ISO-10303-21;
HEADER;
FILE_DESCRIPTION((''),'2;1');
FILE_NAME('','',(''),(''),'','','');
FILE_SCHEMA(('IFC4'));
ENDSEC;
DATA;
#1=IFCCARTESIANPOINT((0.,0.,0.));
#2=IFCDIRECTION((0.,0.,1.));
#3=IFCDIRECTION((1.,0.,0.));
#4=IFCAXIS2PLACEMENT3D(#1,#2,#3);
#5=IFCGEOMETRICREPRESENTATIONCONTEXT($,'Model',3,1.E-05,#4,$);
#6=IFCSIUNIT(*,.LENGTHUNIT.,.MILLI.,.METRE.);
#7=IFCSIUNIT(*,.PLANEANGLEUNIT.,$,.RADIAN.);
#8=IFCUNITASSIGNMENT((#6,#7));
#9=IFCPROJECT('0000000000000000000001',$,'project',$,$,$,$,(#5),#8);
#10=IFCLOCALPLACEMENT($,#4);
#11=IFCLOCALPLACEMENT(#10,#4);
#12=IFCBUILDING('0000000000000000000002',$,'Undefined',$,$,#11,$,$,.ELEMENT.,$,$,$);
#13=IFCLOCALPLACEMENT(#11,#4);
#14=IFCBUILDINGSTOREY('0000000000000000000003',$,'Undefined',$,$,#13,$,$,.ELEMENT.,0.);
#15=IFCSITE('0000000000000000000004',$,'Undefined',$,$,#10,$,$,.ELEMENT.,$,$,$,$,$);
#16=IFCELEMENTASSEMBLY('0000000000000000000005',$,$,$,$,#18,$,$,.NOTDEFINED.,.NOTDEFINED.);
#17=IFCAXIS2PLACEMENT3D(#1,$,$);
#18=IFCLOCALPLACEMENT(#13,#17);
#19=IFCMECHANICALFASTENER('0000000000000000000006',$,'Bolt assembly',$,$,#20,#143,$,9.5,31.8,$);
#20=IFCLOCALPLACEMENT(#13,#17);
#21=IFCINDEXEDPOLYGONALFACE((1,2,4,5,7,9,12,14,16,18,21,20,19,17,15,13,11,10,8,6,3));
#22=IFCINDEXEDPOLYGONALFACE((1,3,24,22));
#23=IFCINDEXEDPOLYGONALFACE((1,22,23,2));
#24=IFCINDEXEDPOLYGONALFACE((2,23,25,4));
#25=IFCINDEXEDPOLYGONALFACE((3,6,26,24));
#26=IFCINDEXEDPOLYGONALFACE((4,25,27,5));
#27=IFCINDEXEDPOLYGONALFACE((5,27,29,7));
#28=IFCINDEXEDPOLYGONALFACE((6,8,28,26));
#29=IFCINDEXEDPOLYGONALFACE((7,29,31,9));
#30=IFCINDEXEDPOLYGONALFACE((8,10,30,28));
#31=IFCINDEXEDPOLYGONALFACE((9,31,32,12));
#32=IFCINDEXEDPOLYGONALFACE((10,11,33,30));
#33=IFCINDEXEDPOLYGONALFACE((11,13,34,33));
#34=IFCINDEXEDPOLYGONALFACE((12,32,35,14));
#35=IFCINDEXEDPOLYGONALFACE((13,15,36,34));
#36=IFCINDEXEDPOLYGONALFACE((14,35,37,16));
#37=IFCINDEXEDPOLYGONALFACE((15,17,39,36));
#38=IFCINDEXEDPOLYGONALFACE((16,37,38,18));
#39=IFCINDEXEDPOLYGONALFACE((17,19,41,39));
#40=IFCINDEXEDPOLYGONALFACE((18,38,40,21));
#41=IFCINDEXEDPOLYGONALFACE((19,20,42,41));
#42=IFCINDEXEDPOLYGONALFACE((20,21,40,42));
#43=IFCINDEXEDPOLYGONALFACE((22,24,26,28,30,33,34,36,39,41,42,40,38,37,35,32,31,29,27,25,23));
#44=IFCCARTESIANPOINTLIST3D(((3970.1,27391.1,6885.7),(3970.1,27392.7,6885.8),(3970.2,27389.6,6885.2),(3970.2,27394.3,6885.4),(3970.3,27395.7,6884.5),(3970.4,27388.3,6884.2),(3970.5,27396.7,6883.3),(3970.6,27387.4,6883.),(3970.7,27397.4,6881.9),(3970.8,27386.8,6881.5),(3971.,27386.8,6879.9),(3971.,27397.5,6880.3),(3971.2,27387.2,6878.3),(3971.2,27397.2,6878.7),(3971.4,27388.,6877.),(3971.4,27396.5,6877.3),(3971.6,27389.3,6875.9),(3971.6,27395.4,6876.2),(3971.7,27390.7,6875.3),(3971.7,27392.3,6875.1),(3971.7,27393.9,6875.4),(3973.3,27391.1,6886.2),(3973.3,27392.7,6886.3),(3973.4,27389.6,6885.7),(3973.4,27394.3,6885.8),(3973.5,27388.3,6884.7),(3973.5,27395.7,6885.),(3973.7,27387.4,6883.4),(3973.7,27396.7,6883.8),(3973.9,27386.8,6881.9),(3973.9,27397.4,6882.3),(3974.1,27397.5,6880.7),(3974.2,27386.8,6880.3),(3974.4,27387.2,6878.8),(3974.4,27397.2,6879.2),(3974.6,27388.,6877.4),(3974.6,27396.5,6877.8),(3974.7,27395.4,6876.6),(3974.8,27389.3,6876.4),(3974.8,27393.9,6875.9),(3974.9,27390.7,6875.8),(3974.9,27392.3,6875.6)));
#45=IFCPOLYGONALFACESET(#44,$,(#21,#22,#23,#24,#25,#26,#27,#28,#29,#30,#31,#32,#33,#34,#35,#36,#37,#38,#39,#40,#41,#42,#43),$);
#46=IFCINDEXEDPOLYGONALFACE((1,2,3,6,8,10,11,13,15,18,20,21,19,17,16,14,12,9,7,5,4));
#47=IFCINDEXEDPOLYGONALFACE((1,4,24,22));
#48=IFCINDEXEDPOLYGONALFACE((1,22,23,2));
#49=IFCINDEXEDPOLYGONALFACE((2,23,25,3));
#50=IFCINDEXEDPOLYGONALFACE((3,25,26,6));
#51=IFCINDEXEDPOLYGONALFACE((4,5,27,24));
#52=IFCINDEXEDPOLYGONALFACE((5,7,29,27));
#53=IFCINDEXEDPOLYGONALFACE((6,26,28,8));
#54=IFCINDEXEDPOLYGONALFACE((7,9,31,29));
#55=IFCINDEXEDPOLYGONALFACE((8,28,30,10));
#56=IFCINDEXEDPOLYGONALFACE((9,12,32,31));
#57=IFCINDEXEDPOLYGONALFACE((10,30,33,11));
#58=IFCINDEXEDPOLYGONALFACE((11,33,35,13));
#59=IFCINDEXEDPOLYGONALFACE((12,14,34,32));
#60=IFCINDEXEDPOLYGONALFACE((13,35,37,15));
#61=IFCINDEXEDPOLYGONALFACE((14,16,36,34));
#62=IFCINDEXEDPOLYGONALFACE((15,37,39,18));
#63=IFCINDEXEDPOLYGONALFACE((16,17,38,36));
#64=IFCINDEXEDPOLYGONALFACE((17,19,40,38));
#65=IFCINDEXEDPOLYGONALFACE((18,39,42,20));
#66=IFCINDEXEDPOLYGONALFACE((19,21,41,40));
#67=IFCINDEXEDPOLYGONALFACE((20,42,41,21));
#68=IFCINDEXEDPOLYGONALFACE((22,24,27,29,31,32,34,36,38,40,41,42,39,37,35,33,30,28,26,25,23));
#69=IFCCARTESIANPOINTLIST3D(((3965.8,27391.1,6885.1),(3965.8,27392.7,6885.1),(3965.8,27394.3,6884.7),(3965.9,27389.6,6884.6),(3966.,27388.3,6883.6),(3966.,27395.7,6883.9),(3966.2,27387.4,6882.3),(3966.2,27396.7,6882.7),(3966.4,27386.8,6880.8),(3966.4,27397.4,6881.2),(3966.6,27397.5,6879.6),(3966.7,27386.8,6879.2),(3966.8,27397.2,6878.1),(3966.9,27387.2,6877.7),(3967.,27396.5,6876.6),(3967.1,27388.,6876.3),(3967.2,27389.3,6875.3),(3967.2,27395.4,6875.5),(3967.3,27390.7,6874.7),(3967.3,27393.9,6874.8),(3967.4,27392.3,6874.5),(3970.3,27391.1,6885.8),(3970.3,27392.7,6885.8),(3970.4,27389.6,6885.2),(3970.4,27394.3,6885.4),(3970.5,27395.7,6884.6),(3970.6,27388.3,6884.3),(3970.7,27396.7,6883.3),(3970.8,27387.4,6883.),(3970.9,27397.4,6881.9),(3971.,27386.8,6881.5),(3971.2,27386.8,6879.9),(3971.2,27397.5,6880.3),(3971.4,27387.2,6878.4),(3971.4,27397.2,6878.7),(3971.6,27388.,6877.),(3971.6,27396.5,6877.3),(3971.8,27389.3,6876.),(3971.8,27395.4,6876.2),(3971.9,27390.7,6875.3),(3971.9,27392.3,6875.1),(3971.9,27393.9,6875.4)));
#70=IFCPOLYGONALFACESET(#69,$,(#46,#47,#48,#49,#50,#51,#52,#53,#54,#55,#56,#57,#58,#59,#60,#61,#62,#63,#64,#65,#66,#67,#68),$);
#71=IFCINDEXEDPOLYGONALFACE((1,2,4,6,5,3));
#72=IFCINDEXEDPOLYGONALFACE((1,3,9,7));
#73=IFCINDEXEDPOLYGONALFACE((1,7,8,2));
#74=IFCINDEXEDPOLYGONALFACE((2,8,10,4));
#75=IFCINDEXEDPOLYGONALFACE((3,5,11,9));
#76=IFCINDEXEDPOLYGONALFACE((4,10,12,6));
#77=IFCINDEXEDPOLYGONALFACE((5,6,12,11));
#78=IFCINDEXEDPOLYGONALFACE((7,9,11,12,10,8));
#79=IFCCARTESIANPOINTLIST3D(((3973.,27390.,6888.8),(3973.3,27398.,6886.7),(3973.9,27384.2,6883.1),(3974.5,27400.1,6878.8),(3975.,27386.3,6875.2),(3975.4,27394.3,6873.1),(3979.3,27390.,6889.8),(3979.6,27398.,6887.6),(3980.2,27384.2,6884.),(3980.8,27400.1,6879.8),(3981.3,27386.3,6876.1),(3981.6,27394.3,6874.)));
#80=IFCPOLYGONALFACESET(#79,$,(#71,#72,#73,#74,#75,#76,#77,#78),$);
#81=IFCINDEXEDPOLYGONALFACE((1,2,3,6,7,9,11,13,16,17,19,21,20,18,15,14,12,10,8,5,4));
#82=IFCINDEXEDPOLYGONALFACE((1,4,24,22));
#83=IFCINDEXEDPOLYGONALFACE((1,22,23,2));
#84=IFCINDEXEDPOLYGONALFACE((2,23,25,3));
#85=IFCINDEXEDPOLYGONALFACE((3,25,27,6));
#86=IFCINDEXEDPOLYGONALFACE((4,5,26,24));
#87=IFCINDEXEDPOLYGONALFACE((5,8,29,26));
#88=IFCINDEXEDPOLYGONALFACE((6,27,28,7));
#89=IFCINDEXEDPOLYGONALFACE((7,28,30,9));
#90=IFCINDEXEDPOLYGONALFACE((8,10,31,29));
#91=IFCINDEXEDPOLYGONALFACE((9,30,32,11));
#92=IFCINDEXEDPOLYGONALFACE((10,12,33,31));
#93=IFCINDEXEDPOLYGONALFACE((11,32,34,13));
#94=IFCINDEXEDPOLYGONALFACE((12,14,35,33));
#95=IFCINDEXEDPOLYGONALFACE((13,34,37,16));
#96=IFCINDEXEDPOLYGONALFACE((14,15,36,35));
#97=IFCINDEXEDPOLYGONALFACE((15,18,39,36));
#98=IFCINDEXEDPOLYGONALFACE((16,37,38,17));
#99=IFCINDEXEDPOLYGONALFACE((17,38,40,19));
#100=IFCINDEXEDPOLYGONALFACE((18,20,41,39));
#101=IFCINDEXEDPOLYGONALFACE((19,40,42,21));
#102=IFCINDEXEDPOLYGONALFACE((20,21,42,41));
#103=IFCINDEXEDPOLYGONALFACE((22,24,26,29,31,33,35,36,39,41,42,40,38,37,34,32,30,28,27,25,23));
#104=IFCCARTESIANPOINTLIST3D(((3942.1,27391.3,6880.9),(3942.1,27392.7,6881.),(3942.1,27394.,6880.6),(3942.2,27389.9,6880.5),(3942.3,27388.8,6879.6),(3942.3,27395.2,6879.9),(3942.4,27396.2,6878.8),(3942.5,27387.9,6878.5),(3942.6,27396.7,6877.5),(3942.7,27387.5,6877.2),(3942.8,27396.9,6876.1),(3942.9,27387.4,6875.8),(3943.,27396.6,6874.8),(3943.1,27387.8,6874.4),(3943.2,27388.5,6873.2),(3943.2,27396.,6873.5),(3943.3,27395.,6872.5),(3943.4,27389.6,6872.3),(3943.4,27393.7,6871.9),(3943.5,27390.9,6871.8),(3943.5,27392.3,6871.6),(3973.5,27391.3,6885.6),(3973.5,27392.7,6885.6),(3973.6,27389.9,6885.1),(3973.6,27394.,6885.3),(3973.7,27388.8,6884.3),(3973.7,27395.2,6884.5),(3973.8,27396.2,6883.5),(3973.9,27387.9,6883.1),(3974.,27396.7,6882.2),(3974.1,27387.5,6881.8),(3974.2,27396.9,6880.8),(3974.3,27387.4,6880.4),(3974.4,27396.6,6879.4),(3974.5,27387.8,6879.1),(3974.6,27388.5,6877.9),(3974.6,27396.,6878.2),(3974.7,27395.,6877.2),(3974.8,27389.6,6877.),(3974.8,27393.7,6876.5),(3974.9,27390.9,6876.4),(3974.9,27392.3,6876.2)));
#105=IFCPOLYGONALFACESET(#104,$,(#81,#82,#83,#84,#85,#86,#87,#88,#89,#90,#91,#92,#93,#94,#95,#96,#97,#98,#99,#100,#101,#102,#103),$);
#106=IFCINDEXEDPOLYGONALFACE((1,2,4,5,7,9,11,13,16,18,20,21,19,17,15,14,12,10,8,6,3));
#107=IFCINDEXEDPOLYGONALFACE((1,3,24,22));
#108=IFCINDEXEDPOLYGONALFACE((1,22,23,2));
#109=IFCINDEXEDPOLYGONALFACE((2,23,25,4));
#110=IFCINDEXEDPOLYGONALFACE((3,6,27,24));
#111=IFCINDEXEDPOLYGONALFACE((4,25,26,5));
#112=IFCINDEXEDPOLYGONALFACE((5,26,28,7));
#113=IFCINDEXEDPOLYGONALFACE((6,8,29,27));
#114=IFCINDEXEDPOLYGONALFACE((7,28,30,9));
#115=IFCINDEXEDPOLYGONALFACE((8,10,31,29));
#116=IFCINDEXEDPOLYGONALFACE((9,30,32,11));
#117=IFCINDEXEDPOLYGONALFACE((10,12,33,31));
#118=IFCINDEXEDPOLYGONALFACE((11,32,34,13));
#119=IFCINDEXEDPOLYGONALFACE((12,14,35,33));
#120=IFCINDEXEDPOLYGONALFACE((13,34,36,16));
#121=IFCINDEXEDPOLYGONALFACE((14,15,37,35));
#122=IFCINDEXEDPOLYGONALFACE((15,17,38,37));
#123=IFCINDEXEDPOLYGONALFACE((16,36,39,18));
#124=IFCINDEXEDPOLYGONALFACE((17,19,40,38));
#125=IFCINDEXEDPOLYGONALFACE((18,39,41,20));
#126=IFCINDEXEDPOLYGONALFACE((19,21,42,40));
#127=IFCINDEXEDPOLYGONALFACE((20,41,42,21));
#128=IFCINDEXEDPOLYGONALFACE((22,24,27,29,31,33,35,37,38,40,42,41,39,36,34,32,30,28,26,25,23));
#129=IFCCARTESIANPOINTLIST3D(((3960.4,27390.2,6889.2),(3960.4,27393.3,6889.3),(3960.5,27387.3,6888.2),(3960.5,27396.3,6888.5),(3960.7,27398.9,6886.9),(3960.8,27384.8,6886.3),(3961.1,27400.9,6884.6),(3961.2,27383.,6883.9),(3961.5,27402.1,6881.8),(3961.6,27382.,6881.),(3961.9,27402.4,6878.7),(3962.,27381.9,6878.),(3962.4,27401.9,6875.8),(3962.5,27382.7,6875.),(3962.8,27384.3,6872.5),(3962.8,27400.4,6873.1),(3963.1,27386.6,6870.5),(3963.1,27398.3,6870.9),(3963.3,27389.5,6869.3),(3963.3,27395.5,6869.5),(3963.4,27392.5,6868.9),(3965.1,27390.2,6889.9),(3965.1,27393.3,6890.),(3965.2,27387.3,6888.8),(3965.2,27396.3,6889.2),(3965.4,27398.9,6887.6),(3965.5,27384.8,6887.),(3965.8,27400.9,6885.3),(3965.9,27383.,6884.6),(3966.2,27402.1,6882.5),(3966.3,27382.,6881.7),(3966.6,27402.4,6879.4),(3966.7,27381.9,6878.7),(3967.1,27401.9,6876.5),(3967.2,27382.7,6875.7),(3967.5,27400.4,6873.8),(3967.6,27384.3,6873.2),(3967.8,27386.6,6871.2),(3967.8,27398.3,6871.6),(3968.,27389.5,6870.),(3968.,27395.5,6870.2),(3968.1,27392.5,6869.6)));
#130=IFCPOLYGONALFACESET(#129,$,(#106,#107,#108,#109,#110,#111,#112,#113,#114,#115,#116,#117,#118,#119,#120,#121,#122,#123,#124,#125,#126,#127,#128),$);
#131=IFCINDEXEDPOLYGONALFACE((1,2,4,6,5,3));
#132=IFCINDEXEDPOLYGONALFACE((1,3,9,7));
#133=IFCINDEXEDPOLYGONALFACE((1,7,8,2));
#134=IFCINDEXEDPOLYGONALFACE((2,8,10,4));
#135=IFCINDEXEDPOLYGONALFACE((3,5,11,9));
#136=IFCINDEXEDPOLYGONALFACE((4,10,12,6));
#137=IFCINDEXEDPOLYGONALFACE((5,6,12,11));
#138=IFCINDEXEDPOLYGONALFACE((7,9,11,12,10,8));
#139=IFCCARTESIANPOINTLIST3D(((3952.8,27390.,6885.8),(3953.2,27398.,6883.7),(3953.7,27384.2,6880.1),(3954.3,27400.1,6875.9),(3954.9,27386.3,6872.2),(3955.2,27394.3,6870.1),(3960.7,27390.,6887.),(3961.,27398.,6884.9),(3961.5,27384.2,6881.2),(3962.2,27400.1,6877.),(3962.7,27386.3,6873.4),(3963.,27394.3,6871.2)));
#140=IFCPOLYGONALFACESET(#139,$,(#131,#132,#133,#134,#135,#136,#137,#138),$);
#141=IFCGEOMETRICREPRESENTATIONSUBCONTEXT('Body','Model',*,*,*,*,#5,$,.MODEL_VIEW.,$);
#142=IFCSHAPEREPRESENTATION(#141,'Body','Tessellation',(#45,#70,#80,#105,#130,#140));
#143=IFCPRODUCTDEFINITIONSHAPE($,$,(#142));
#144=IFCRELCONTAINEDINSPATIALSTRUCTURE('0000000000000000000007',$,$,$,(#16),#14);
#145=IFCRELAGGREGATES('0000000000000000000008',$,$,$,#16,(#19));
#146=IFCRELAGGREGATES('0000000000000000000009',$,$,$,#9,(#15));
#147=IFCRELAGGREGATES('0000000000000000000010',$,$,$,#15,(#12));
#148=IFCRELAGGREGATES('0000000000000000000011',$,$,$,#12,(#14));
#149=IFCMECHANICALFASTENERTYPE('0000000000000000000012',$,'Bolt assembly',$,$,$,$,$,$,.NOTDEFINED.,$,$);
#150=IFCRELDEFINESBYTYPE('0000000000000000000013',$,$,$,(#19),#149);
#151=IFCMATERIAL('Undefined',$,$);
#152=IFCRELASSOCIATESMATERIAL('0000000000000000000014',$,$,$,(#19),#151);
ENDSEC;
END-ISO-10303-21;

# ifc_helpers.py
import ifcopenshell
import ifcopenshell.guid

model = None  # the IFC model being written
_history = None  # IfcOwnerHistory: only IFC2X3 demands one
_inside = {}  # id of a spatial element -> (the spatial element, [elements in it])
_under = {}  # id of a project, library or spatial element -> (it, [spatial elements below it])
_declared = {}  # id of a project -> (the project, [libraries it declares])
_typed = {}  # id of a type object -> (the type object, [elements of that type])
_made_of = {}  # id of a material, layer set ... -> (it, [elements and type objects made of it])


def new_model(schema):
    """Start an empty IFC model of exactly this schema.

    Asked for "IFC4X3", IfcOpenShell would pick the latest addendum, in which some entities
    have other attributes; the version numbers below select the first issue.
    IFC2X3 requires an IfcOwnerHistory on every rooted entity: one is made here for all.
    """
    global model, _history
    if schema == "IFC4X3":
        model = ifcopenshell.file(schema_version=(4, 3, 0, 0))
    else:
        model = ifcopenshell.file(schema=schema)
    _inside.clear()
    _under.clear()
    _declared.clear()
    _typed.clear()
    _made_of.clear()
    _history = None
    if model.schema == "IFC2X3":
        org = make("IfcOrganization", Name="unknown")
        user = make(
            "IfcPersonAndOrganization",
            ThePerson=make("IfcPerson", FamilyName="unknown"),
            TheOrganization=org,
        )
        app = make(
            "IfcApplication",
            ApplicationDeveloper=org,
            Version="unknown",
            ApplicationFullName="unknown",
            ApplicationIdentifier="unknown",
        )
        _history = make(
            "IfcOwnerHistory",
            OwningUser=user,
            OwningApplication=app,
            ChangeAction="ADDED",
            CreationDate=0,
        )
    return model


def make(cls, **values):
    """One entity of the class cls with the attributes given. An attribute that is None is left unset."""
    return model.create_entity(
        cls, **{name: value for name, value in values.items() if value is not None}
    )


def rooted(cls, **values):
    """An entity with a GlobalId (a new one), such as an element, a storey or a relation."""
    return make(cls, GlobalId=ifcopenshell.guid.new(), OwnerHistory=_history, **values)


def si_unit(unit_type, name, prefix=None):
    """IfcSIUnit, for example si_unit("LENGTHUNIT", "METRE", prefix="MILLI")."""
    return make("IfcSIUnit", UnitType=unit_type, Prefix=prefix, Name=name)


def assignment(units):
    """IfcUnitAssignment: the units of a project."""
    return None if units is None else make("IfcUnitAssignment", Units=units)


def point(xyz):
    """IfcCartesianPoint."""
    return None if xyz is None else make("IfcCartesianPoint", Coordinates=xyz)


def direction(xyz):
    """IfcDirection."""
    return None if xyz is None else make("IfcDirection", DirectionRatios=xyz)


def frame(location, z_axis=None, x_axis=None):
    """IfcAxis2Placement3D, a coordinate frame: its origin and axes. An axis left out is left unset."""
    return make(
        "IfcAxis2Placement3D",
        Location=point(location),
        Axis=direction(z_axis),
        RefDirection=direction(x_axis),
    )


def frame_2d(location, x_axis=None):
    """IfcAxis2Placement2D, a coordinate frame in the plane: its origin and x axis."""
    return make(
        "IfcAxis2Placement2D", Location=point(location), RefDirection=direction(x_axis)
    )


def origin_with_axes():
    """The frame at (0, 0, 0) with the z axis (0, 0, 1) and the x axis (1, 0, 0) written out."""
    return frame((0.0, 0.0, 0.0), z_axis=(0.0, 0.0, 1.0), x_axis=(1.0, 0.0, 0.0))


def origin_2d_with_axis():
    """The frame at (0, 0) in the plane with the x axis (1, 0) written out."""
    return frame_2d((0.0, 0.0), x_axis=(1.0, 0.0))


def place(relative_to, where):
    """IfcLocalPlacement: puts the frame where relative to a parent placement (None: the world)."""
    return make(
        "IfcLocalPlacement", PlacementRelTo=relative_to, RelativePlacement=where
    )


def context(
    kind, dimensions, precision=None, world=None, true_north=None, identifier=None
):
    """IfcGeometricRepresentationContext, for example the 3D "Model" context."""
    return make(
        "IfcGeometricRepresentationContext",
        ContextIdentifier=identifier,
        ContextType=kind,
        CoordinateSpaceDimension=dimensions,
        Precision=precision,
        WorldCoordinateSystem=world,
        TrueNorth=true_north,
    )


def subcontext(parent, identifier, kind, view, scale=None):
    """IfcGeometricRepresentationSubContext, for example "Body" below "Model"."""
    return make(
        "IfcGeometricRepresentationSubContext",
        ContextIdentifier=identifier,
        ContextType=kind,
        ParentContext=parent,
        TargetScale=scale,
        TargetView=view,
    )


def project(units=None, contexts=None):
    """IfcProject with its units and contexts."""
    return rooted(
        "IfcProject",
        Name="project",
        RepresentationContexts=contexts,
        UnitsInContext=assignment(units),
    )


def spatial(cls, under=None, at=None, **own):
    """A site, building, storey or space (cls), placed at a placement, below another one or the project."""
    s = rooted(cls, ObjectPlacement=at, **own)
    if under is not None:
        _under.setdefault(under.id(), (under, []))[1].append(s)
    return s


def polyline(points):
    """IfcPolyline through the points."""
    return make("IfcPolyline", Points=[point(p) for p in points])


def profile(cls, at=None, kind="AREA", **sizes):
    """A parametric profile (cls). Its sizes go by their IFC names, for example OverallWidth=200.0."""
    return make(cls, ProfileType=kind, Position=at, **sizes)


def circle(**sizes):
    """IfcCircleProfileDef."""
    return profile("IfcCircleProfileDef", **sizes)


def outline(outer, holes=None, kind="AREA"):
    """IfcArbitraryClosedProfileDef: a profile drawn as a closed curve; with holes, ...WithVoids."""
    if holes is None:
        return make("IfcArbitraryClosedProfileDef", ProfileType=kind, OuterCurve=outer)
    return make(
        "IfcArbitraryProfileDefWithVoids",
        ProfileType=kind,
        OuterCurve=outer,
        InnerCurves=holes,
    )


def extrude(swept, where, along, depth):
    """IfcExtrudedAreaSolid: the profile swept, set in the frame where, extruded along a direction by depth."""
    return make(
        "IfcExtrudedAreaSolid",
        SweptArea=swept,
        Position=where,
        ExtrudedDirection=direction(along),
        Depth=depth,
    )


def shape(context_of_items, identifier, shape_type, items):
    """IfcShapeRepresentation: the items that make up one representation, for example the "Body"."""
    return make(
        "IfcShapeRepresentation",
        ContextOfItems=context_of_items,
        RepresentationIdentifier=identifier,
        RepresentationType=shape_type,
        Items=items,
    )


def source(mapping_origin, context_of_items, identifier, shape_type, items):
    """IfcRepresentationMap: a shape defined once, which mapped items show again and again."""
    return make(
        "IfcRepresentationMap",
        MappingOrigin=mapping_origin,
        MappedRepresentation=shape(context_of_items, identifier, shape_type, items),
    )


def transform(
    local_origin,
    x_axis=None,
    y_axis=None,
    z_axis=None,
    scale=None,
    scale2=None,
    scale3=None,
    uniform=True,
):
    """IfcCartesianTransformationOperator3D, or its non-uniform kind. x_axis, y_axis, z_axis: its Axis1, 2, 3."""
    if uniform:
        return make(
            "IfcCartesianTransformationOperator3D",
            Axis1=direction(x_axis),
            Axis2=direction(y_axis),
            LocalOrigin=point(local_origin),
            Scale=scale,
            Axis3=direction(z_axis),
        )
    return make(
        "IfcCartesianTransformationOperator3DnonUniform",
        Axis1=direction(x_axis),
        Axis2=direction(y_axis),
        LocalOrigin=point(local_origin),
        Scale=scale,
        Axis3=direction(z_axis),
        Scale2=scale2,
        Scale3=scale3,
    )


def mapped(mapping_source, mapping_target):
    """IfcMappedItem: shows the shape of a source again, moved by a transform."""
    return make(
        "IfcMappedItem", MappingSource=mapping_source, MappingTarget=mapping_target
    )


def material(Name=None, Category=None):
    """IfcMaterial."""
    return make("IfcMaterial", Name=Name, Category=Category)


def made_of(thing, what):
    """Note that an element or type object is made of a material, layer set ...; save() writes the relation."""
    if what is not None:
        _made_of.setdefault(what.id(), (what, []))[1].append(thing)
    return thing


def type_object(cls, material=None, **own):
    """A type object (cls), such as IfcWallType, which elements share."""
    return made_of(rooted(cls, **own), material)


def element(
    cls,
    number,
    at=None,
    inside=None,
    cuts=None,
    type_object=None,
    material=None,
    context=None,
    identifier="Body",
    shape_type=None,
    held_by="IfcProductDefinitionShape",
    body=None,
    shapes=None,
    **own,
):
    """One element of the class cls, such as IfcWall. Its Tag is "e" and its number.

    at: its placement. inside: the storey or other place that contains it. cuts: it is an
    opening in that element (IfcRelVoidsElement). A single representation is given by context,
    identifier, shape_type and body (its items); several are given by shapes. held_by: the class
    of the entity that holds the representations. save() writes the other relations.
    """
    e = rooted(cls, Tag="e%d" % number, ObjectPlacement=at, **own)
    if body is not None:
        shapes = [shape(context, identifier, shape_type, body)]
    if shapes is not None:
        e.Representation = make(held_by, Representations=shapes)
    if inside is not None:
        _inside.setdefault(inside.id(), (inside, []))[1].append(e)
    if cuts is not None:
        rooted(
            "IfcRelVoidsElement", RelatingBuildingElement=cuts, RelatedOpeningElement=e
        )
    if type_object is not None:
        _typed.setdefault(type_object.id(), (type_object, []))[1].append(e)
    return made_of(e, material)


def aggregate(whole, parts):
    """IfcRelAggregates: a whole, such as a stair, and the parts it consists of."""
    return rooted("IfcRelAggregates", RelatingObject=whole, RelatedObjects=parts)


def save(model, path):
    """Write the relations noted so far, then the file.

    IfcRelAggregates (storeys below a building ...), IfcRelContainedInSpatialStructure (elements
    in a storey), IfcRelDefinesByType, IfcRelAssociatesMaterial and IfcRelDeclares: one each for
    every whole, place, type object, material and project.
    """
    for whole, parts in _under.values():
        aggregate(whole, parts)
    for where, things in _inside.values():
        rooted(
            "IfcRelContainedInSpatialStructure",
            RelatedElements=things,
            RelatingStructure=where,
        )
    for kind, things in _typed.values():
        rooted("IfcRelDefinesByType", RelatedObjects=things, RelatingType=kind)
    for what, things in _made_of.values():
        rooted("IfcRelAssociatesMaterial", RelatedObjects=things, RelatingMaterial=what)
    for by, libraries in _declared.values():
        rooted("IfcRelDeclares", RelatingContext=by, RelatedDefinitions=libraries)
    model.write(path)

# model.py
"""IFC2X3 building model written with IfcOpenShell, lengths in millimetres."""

from ifc_helpers import new_model, si_unit, frame, origin_with_axes, origin_2d_with_axis, place, context, subcontext, project, spatial, polyline, circle, outline, extrude, source, transform, mapped, material, type_object, element, aggregate, save


model = new_model("IFC2X3")

# Units and contexts
model_context = context("Model", 3, precision=1e-05, world=origin_with_axes())
body_context = subcontext(model_context, "Body", "Model", "MODEL_VIEW")
ifc_project = project(units=[si_unit("LENGTHUNIT", "METRE", prefix="MILLI"), si_unit("PLANEANGLEUNIT", "RADIAN")], contexts=[model_context])

# Site, building, storey
site_placement = place(None, origin_with_axes())
site = spatial("IfcSite", under=ifc_project, at=site_placement, Name="Undefined", CompositionType="ELEMENT")
building_placement = place(site_placement, origin_with_axes())
building = spatial("IfcBuilding", under=site, at=building_placement, Name="Undefined", CompositionType="ELEMENT")
storey_placement = place(building_placement, origin_with_axes())
storey = spatial("IfcBuildingStorey", under=building, at=storey_placement, Name="Undefined", CompositionType="ELEMENT", Elevation=0.0)

# Element assembly
assembly_1_placement = place(storey_placement, origin_with_axes())
assembly_1 = element("IfcElementAssembly", 1, at=assembly_1_placement, inside=storey, AssemblyPlace="NOTDEFINED", PredefinedType="NOTDEFINED")

# Shared definitions
ifc_material_1 = material(Name="Undefined")
mechanical_fastener_type = type_object("IfcMechanicalFastenerType", Name="Bolt assembly")

# Mechanical fastener
shared_shape_1 = source(origin_with_axes(), body_context, "Body", "SweptSolid", [
    extrude(circle(Radius=5.4, at=origin_2d_with_axis()), frame((0.0, -3.1, 0.0), z_axis=(0.0, 1.0, 0.0), x_axis=(1.0, 0.0, 0.0)), (0.0, 0.0, 1.0), 3.2),
    extrude(circle(Radius=5.4, at=origin_2d_with_axis()), frame((0.0, -0.1, 0.0), z_axis=(0.0, 1.0, 0.0), x_axis=(1.0, 0.0, 0.0)), (0.0, 0.0, 1.0), 4.6),
    extrude(outline(polyline([(7.1, -4.1), (7.1, 4.1), (0.0, 8.2), (-7.1, 4.1), (-7.1, -4.1), (0.0, -8.2), (7.1, -4.1)])), frame((0.0, -9.6, 0.0), z_axis=(0.0, 1.0, 0.0), x_axis=(1.0, 0.0, 0.0)), (0.0, 0.0, 1.0), 6.3),
    extrude(circle(Radius=4.8, at=origin_2d_with_axis()), frame((0.0, -3.2, 0.0), z_axis=(0.0, 1.0, 0.0), x_axis=(1.0, 0.0, 0.0)), (0.0, 0.0, 1.0), 31.8),
    extrude(circle(Radius=10.3, at=origin_2d_with_axis()), frame((0.0, 4.5, 0.0), z_axis=(0.0, 1.0, 0.0), x_axis=(1.0, 0.0, 0.0)), (0.0, 0.0, 1.0), 4.8),
    extrude(outline(polyline([(7.1, -4.1), (7.1, 4.1), (0.0, 8.2), (-7.1, 4.1), (-7.1, -4.1), (0.0, -8.2), (7.1, -4.1)])), frame((0.0, 9.3, 0.0), z_axis=(0.0, 1.0, 0.0), x_axis=(1.0, 0.0, 0.0)), (0.0, 0.0, 1.0), 7.9),
])
mechanical_fastener_1_placement = place(assembly_1_placement, frame((3971.0, 27392.1, 6880.5), z_axis=(0.103381, -0.707107, -0.699509), x_axis=(-0.103381, -0.707107, 0.699509)))
mechanical_fastener_1 = element("IfcMechanicalFastener", 2, at=mechanical_fastener_1_placement, type_object=mechanical_fastener_type, material=ifc_material_1, Name="Bolt assembly", NominalDiameter=9.5, NominalLength=31.8, context=body_context, shape_type="MappedRepresentation", body=[
    mapped(shared_shape_1, transform((0.0, 0.0, 0.0))),
])
aggregate(assembly_1, [mechanical_fastener_1])

save(model, "model.ifc")
